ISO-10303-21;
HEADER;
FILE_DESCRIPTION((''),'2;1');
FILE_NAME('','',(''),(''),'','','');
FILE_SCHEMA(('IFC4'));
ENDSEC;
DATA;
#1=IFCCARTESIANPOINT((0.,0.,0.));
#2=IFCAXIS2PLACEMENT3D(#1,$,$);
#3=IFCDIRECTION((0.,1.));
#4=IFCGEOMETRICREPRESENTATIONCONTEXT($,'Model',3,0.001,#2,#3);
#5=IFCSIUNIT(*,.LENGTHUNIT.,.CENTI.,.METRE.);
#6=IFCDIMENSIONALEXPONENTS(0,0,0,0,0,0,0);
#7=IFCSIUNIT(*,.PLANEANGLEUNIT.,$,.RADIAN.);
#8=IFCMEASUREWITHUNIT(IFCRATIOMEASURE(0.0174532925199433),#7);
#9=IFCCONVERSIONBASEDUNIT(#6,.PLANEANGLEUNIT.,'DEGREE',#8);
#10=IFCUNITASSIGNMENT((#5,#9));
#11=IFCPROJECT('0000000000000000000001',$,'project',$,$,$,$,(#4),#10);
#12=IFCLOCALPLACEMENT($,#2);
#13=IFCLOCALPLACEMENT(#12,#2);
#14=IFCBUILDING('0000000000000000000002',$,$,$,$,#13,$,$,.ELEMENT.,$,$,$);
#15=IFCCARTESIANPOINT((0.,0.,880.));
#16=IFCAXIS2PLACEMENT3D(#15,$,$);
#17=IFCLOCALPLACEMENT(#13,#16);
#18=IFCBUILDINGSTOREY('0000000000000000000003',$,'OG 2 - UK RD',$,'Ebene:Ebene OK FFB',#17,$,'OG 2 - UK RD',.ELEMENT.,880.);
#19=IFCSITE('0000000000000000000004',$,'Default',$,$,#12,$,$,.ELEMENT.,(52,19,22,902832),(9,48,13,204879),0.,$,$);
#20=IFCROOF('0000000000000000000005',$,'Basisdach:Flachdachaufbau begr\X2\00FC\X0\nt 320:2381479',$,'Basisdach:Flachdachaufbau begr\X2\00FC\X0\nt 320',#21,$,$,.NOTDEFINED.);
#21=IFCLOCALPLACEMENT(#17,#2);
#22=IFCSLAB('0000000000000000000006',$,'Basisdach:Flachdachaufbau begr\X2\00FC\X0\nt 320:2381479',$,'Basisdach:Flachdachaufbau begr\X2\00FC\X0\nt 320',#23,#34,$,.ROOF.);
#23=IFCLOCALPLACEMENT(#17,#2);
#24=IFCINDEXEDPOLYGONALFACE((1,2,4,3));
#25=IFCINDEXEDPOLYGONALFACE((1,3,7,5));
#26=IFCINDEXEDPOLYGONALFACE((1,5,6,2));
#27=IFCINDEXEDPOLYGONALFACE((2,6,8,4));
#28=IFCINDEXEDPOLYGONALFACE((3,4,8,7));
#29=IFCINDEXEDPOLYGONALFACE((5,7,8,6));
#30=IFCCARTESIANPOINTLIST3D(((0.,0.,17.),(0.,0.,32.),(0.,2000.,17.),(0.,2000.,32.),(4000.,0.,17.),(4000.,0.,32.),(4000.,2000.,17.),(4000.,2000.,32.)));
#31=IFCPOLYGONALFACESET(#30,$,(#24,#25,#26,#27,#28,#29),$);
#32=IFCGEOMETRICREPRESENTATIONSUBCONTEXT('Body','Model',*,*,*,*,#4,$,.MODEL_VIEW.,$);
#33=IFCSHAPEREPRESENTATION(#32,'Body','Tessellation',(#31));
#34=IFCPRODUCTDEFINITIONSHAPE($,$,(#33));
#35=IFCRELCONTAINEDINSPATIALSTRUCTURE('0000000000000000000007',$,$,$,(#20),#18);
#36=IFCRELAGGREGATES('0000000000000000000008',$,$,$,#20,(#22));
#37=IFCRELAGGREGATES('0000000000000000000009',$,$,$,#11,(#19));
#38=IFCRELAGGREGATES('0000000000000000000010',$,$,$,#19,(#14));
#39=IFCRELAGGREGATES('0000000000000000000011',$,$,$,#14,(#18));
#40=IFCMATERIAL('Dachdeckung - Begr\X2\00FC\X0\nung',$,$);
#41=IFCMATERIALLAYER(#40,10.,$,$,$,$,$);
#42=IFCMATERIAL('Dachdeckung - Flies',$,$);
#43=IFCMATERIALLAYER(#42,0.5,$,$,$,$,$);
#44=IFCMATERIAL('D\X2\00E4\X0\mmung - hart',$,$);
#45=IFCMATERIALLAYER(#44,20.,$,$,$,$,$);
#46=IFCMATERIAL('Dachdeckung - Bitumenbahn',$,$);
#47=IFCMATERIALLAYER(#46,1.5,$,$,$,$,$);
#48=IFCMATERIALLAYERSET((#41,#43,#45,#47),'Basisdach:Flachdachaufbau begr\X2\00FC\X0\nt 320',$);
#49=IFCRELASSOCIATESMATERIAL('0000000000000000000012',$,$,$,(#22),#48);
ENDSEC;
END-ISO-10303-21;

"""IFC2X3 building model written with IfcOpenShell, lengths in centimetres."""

from ifc_helpers import new_model, entity, si_unit, converted_unit, direction, frame, origin, origin_2d_with_axis, place, context, subcontext, project, spatial, rectangle, extrude, material, layer, layer_set, element, aggregate, save


model = new_model("IFC2X3")

# Units and contexts
model_context = context("Model", 3, precision=0.001, world=origin(), true_north=direction((0.0, 1.0)))
body_context = subcontext(model_context, "Body", "Model", "MODEL_VIEW")
ifc_project = project(units=[si_unit("LENGTHUNIT", "METRE", prefix="CENTI"), converted_unit("PLANEANGLEUNIT", "DEGREE", entity("IfcRatioMeasure", 0.0174532925199433), si_unit("PLANEANGLEUNIT", "RADIAN"), dimensions=[0, 0, 0, 0, 0, 0, 0])], contexts=[model_context])

# Site, building, storey
site_placement = place(None, frame((0.0, 0.0, 0.0)))
site = spatial("IfcSite", under=ifc_project, at=site_placement, Name="Default", CompositionType="ELEMENT", RefLatitude=(52, 19, 22, 902832), RefLongitude=(9, 48, 13, 204879), RefElevation=0.0)
building_placement = place(site_placement, origin())
building = spatial("IfcBuilding", under=site, at=building_placement, CompositionType="ELEMENT")
storey_placement = place(building_placement, frame((0.0, 0.0, 880.0)))
storey = spatial("IfcBuildingStorey", under=building, at=storey_placement, Name="OG 2 - UK RD", ObjectType="Ebene:Ebene OK FFB", LongName="OG 2 - UK RD", CompositionType="ELEMENT", Elevation=880.0)

# Roof, slab
roof_placement = place(storey_placement, frame((0.0, 0.0, 17.0)))
roof = element("IfcRoof", 1, at=roof_placement, inside=storey, Name="Basisdach:Flachdachaufbau begrünt 320:2381479", ObjectType="Basisdach:Flachdachaufbau begrünt 320", ShapeType="NOTDEFINED")
ifc_material_1 = material(Name="Dachdeckung - Begrünung")
ifc_layer_1 = layer(ifc_material_1, 10.0)
ifc_material_2 = material(Name="Dachdeckung - Flies")
ifc_layer_2 = layer(ifc_material_2, 0.5)
ifc_material_3 = material(Name="Dämmung - hart")
ifc_layer_3 = layer(ifc_material_3, 20.0)
ifc_material_4 = material(Name="Dachdeckung - Bitumenbahn")
ifc_layer_4 = layer(ifc_material_4, 1.5)
ifc_layer_set = layer_set([ifc_layer_1, ifc_layer_2, ifc_layer_3, ifc_layer_4], Name="Basisdach:Flachdachaufbau begrünt 320")
slab_placement = place(roof_placement, origin())
slab = element("IfcSlab", 2, at=slab_placement, material=ifc_layer_set, Name="Basisdach:Flachdachaufbau begrünt 320:2381479", ObjectType="Basisdach:Flachdachaufbau begrünt 320", PredefinedType="ROOF", context=body_context, shape_type="SweptSolid", body=[
    extrude(rectangle(XDim=4000.0, YDim=2000.0, at=origin_2d_with_axis()), frame((2000.0, 1000.0, 0.0)), (0.0, 0.0, 1.0), 15.0),
])
aggregate(roof, [slab])

save(model, "model.ifc")
